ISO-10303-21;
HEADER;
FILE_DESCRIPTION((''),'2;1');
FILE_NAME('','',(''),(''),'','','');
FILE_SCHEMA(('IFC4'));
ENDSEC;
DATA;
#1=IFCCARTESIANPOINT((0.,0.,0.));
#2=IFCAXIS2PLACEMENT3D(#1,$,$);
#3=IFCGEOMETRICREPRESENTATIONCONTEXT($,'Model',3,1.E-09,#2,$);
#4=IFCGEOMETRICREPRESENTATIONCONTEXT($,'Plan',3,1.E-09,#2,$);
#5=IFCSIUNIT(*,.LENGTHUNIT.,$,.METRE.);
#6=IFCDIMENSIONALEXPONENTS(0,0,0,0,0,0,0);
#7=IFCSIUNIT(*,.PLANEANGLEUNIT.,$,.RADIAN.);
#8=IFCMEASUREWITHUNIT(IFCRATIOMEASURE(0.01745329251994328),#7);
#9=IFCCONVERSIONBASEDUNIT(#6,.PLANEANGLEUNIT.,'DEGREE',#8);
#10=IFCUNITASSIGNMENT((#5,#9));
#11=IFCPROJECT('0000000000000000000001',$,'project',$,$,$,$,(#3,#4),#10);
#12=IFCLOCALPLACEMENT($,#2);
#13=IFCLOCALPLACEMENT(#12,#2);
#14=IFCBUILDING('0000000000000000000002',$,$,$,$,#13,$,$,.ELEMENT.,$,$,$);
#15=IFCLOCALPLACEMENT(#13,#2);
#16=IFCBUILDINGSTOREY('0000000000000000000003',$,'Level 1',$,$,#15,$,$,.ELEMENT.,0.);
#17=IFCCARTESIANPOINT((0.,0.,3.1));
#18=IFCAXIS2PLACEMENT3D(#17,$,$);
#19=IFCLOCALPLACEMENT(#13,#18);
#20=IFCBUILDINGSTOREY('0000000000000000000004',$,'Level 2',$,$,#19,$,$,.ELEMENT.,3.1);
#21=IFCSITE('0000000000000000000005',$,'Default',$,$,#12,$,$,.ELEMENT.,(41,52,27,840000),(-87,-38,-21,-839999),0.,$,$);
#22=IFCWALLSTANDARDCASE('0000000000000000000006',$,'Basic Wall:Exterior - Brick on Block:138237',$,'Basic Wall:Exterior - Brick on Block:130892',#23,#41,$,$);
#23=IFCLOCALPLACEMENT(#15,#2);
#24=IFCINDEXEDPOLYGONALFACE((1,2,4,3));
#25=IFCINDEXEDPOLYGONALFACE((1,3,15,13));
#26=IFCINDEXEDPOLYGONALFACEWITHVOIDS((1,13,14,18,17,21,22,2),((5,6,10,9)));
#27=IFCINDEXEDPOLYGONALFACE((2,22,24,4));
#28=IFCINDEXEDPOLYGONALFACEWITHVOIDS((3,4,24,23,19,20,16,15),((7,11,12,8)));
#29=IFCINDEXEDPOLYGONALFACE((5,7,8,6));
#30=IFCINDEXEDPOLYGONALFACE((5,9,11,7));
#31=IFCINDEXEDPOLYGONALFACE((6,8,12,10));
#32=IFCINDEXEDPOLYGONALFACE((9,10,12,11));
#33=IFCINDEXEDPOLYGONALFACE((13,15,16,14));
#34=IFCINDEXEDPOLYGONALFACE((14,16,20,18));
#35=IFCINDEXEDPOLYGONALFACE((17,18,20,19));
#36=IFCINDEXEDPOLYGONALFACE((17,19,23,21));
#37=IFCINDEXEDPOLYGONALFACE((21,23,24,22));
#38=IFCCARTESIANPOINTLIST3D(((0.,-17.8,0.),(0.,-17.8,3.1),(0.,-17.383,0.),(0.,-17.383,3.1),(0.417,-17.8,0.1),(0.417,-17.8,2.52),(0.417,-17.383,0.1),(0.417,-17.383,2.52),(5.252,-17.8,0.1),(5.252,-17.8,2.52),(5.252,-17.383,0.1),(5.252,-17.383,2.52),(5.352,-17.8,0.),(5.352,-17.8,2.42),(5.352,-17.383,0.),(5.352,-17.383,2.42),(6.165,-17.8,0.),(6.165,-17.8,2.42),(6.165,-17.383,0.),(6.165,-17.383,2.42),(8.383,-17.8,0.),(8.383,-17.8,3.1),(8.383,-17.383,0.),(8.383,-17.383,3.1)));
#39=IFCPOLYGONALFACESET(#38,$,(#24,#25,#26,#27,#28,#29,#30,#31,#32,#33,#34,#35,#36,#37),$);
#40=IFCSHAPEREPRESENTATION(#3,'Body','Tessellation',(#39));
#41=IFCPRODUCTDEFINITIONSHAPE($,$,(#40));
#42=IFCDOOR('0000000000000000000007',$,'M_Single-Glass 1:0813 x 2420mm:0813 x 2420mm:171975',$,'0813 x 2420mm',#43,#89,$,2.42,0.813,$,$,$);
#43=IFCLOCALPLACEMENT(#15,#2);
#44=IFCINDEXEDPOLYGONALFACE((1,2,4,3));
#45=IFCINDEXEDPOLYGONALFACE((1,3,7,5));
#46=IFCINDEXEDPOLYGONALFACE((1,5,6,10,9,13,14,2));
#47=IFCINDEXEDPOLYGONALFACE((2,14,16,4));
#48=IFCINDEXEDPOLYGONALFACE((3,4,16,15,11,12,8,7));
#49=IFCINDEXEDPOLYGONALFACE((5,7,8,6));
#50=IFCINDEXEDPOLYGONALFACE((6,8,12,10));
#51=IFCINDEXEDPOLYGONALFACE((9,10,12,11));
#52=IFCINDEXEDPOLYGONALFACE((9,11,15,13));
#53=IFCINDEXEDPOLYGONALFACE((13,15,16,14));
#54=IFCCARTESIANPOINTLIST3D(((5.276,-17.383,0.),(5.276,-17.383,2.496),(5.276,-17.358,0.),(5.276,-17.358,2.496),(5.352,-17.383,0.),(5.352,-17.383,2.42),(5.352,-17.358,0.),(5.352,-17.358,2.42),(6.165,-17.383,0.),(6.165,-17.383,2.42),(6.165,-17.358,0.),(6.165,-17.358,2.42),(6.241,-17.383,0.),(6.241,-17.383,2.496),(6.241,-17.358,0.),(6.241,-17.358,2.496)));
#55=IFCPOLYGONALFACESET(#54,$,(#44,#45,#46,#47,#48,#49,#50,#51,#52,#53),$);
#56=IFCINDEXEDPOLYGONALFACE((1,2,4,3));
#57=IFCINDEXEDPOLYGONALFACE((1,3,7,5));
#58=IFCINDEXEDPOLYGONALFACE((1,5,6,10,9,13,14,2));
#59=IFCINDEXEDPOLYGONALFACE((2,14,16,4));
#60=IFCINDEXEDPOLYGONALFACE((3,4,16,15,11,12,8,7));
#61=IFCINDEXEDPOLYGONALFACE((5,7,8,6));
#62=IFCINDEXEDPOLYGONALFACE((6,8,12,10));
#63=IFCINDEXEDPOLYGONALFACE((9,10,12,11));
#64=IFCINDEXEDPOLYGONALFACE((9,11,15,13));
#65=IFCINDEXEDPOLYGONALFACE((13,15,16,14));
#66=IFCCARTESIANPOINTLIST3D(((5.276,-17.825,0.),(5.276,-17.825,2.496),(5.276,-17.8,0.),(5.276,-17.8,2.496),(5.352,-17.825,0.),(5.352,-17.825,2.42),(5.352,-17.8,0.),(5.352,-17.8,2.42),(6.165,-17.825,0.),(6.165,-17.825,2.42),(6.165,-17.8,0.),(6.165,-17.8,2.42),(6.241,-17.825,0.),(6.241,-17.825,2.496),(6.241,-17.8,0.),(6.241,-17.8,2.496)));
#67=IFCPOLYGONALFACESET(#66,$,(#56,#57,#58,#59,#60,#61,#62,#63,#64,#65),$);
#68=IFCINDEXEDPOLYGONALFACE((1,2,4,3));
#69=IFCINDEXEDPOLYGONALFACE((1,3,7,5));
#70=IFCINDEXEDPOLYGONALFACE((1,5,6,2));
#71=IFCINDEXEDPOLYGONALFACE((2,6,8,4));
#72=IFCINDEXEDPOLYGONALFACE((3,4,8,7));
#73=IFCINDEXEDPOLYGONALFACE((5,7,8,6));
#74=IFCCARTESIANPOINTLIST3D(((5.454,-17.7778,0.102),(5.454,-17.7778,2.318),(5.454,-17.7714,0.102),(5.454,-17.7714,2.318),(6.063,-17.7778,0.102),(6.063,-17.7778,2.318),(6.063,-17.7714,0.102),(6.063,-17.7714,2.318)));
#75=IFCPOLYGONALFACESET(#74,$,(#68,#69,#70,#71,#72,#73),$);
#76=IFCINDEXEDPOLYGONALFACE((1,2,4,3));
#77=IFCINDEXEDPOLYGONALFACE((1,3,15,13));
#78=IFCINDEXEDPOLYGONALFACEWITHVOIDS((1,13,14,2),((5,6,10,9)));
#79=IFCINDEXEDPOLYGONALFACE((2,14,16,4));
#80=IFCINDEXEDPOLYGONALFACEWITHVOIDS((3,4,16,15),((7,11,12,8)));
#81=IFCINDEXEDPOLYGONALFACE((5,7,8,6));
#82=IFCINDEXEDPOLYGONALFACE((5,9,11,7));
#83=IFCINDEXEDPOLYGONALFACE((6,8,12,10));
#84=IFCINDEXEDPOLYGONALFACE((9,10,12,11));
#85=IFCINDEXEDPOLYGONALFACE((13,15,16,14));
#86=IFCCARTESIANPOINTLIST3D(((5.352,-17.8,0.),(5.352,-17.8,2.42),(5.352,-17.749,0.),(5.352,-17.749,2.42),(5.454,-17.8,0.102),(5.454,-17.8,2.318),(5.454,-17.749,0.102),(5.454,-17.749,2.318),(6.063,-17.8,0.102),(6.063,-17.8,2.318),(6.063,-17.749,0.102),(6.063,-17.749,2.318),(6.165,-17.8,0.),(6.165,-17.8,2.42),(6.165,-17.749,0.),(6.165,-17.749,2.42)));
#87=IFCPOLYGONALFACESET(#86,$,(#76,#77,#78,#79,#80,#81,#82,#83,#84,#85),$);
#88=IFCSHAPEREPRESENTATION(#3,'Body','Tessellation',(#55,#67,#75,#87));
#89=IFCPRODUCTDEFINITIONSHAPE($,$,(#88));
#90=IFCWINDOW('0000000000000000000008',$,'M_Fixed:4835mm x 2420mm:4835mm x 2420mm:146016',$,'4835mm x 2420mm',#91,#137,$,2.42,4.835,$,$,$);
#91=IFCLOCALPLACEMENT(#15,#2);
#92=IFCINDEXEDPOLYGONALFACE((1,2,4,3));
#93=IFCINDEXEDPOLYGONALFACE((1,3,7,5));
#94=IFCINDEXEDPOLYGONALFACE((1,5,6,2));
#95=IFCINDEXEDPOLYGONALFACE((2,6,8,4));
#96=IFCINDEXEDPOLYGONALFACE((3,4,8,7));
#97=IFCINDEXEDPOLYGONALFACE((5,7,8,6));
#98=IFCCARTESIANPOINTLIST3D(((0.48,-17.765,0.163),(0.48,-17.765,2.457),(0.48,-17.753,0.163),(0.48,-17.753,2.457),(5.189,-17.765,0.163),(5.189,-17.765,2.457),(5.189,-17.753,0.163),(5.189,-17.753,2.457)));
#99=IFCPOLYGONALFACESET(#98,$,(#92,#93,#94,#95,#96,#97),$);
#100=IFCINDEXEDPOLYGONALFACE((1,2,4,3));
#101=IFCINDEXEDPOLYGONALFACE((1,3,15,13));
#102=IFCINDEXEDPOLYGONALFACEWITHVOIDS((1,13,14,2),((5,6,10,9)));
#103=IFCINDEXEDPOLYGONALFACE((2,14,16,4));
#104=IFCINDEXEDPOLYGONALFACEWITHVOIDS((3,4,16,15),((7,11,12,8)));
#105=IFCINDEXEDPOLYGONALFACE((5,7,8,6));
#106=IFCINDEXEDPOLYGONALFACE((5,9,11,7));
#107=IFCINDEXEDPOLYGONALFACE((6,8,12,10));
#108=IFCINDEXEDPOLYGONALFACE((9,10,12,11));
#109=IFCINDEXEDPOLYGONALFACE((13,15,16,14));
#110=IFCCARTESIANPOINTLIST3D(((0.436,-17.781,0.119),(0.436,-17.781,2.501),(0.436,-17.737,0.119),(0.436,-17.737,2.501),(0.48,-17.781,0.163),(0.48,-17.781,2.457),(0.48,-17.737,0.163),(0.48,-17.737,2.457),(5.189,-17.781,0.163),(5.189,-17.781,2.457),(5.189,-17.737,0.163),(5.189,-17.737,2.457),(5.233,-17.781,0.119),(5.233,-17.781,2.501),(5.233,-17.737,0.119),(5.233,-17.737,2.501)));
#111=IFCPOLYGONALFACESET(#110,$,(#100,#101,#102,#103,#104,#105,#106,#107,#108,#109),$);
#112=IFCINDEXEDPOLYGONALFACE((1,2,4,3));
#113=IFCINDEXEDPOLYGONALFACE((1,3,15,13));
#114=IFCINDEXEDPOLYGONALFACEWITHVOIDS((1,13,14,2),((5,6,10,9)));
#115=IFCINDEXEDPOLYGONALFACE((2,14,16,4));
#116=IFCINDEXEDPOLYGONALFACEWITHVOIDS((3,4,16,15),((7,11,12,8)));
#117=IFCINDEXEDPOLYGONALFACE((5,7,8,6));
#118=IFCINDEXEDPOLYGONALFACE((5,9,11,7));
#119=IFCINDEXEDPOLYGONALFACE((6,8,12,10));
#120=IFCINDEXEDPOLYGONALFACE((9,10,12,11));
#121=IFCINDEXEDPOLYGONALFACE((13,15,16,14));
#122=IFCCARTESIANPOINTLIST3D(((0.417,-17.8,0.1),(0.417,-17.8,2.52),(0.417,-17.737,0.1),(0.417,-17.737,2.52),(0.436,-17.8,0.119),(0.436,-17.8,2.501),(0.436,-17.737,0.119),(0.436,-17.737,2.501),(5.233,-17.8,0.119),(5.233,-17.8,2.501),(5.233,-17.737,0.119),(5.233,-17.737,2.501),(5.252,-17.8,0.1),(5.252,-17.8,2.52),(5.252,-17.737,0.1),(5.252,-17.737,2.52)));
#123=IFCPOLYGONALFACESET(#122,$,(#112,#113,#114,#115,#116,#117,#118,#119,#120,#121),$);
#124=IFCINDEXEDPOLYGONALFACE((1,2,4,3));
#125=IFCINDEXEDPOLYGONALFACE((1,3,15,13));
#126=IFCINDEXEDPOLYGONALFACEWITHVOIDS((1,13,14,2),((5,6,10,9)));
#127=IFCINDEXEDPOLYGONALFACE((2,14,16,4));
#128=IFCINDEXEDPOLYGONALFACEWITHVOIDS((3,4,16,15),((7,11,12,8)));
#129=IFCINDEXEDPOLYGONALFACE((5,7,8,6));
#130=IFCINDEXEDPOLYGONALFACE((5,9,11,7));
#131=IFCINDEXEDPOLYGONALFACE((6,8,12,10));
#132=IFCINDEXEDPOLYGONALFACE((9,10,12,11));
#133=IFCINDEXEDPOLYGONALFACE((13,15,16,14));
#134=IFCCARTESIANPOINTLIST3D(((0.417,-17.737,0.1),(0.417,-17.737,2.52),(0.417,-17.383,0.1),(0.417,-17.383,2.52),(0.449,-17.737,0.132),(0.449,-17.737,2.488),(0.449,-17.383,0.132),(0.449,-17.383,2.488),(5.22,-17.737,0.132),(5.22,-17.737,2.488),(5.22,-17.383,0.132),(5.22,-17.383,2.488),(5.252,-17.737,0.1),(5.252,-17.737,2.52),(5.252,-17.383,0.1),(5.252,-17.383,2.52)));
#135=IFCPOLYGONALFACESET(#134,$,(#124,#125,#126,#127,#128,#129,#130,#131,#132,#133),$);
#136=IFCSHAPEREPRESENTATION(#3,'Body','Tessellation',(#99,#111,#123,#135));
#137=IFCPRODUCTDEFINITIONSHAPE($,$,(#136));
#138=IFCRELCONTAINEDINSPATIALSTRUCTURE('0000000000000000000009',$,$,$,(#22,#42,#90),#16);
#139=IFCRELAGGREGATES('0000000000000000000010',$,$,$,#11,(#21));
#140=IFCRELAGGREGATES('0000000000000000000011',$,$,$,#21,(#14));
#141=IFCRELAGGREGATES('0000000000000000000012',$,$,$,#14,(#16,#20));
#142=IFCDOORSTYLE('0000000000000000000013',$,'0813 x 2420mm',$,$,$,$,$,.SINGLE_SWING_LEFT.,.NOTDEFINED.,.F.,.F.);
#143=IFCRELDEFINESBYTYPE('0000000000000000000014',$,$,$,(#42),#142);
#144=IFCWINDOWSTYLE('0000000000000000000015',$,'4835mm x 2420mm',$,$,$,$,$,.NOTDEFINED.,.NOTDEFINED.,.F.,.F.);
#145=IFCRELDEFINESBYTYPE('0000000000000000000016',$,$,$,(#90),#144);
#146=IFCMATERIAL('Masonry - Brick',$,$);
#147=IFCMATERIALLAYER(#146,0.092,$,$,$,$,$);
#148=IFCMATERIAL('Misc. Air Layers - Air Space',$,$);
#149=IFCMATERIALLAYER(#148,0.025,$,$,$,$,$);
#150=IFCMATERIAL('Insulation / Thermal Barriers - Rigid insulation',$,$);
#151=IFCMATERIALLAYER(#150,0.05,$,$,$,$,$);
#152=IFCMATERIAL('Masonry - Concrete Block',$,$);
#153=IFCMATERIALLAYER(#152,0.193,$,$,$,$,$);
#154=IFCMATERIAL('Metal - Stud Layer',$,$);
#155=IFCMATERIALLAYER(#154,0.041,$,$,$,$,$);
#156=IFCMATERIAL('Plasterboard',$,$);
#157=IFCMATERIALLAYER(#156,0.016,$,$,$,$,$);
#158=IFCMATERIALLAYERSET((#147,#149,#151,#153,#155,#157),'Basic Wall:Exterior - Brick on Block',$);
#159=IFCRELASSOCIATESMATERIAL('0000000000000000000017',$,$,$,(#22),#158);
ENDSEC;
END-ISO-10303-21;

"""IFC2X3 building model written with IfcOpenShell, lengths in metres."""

from ifc_helpers import new_model, entity, si_unit, converted_unit, frame, frame_2d, origin, origin_2d_with_axis, place, context, project, spatial, polyline, rectangle, outline, extrude, source, transform, mapped, material, layer, layer_set, layer_usage, type_object, type_shapes, element, fill, save


model = new_model("IFC2X3")

# Units and contexts
model_context = context("Model", 3, precision=1e-09, world=origin())
plan_context = context("Plan", 3, precision=1e-09, world=origin())
ifc_project = project(units=[si_unit("LENGTHUNIT", "METRE"), converted_unit("PLANEANGLEUNIT", "DEGREE", entity("IfcRatioMeasure", 0.01745329251994328), si_unit("PLANEANGLEUNIT", "RADIAN"), dimensions=[0, 0, 0, 0, 0, 0, 0])], contexts=[model_context, plan_context])

# Site, building, storey
site_placement = place(None, origin())
site = spatial("IfcSite", under=ifc_project, at=site_placement, Name="Default", CompositionType="ELEMENT", RefLatitude=(41, 52, 27, 840000), RefLongitude=(-87, -38, -21, -839999), RefElevation=0.0)
building_placement = place(site_placement, origin())
building = spatial("IfcBuilding", under=site, at=building_placement, CompositionType="ELEMENT")
storey_1_placement = place(building_placement, origin())
storey_1 = spatial("IfcBuildingStorey", under=building, at=storey_1_placement, Name="Level 1", CompositionType="ELEMENT", Elevation=0.0)

# Shared definitions
ifc_material_1 = material(Name="Masonry - Brick")
ifc_layer_1 = layer(ifc_material_1, 0.092)
ifc_material_2 = material(Name="Misc. Air Layers - Air Space")
ifc_layer_2 = layer(ifc_material_2, 0.025)
ifc_material_3 = material(Name="Insulation / Thermal Barriers - Rigid insulation")
ifc_layer_3 = layer(ifc_material_3, 0.05)
ifc_material_4 = material(Name="Masonry - Concrete Block")
ifc_layer_4 = layer(ifc_material_4, 0.193)
ifc_material_5 = material(Name="Metal - Stud Layer")
ifc_layer_5 = layer(ifc_material_5, 0.041)
ifc_material_6 = material(Name="Plasterboard")
ifc_layer_6 = layer(ifc_material_6, 0.016)
ifc_layer_set_1 = layer_set([ifc_layer_1, ifc_layer_2, ifc_layer_3, ifc_layer_4, ifc_layer_5, ifc_layer_6], Name="Basic Wall:Exterior - Brick on Block")
ifc_layer_usage_1 = layer_usage(ifc_layer_set_1, "AXIS2", "NEGATIVE", 0.2085)

# Shared definitions
storey_2_placement = place(building_placement, frame((0.0, 0.0, 3.1)))
storey_2 = spatial("IfcBuildingStorey", under=building, at=storey_2_placement, Name="Level 2", CompositionType="ELEMENT", Elevation=3.1)

# Wall, openings, door, window
wall_1_placement = place(storey_1_placement, frame((8.383, -17.5915, 0.0), z_axis=(0.0, 0.0, 1.0), x_axis=(-1.0, 0.0, 0.0)))
wall_1 = element("IfcWallStandardCase", 1, at=wall_1_placement, inside=storey_1, material=ifc_layer_usage_1, Name="Basic Wall:Exterior - Brick on Block:138237", ObjectType="Basic Wall:Exterior - Brick on Block:130892", context=model_context, shape_type="SweptSolid", body=[
    extrude(rectangle(XDim=8.383, YDim=0.417, at=frame_2d((4.1915, 0.0), x_axis=(-1.0, 0.0))), origin(), (0.0, 0.0, 1.0), 3.1),
])
opening_1_placement = place(wall_1_placement, frame((3.131, -0.2085, 0.1)))
opening_1 = element("IfcOpeningElement", 2, at=opening_1_placement, cuts=wall_1, ObjectType="Opening", context=model_context, shape_type="SweptSolid", body=[
    extrude(rectangle(XDim=2.42, YDim=4.835, at=frame_2d((1.21, 2.4175), x_axis=(1.0, 0.0))), frame((0.0, 0.0, 0.0), z_axis=(0.0, 1.0, 0.0), x_axis=(0.0, 0.0, 1.0)), (0.0, 0.0, 1.0), 0.417),
])
opening_2_placement = place(wall_1_placement, frame((2.218, -0.2085, 0.0)))
opening_2 = element("IfcOpeningElement", 3, at=opening_2_placement, cuts=wall_1, ObjectType="Opening", context=model_context, shape_type="SweptSolid", body=[
    extrude(rectangle(XDim=0.813, YDim=2.42, at=frame_2d((1.21, 0.4065), x_axis=(0.0, -1.0))), frame((0.0, 0.0, 0.0), z_axis=(0.0, 1.0, 0.0), x_axis=(0.0, 0.0, 1.0)), (0.0, 0.0, 1.0), 0.417),
])
door_style_1 = type_object("IfcDoorStyle", Name="0813 x 2420mm", ConstructionType="NOTDEFINED", OperationType="SINGLE_SWING_LEFT", ParameterTakesPrecedence=False, Sizeable=False)
shared_shape_1 = source(origin(), model_context, "Body", "SweptSolid", [
    extrude(outline(polyline([(-0.4065, -1.191), (-0.4065, 1.229), (-0.4825, 1.229), (-0.4825, -1.267), (0.4825, -1.267), (0.4825, 1.229), (0.4065, 1.229), (0.4065, -1.191), (-0.4065, -1.191)])), frame((0.4065, 0.0, 1.229), z_axis=(0.0, 1.0, 0.0), x_axis=(1.0, 0.0, 0.0)), (0.0, 0.0, -1.0), 0.025),
    extrude(outline(polyline([(-0.4065, -1.191), (-0.4065, 1.229), (-0.4825, 1.229), (-0.4825, -1.267), (0.4825, -1.267), (0.4825, 1.229), (0.4065, 1.229), (0.4065, -1.191), (-0.4065, -1.191)])), frame((0.4065, 0.442, 1.229), z_axis=(0.0, 1.0, 0.0), x_axis=(1.0, 0.0, 0.0)), (0.0, 0.0, -1.0), 0.025),
    extrude(rectangle(XDim=0.609, YDim=0.0064, at=origin_2d_with_axis()), frame((0.4065, 0.3916, 0.102)), (0.0, 0.0, 1.0), 2.216),
    extrude(outline(polyline([(-1.21, -0.4065), (1.21, -0.4065), (1.21, 0.4065), (-1.21, 0.4065), (-1.21, -0.4065)]), holes=[polyline([(-1.108, 0.3045), (1.108, 0.3045), (1.108, -0.3045), (-1.108, -0.3045), (-1.108, 0.3045)])]), frame((0.4065, 0.417, 1.21), z_axis=(0.0, -1.0, 0.0), x_axis=(0.0, 0.0, -1.0)), (0.0, 0.0, 1.0), 0.051),
])
type_shapes(door_style_1, [shared_shape_1])
door_1_placement = place(opening_2_placement, origin())
door_1 = element("IfcDoor", 4, at=door_1_placement, inside=storey_1, type_object=door_style_1, Name="M_Single-Glass 1:0813 x 2420mm:0813 x 2420mm:171975", ObjectType="0813 x 2420mm", OverallHeight=2.42, OverallWidth=0.813, context=model_context, shape_type="MappedRepresentation", body=[
    mapped(shared_shape_1, transform((0.0, 0.0, 0.0), scale=1.0)),
])
fill(opening_2, door_1)
window_style_1 = type_object("IfcWindowStyle", Name="4835mm x 2420mm", ConstructionType="NOTDEFINED", OperationType="NOTDEFINED", ParameterTakesPrecedence=False, Sizeable=False)
shared_shape_2 = source(origin(), model_context, "Body", "SweptSolid", [
    extrude(rectangle(XDim=0.012, YDim=4.709, at=origin_2d_with_axis()), frame((2.4175, 0.376, 0.063), z_axis=(0.0, 0.0, 1.0), x_axis=(0.0, -1.0, 0.0)), (0.0, 0.0, 1.0), 2.294),
    extrude(outline(polyline([(-2.3985, -1.191), (2.3985, -1.191), (2.3985, 1.191), (-2.3985, 1.191), (-2.3985, -1.191)]), holes=[polyline([(-2.3545, -1.147), (-2.3545, 1.147), (2.3545, 1.147), (2.3545, -1.147), (-2.3545, -1.147)])]), frame((2.4175, 0.354, 1.21), z_axis=(0.0, 1.0, 0.0), x_axis=(1.0, 0.0, 0.0)), (0.0, 0.0, 1.0), 0.044),
    extrude(outline(polyline([(-2.4175, -1.21), (2.4175, -1.21), (2.4175, 1.21), (-2.4175, 1.21), (-2.4175, -1.21)]), holes=[polyline([(-2.3985, -1.191), (-2.3985, 1.191), (2.3985, 1.191), (2.3985, -1.191), (-2.3985, -1.191)])]), frame((2.4175, 0.354, 1.21), z_axis=(0.0, 1.0, 0.0), x_axis=(1.0, 0.0, 0.0)), (0.0, 0.0, 1.0), 0.063),
    extrude(outline(polyline([(-2.4175, -1.21), (2.4175, -1.21), (2.4175, 1.21), (-2.4175, 1.21), (-2.4175, -1.21)]), holes=[polyline([(-2.3855, -1.178), (-2.3855, 1.178), (2.3855, 1.178), (2.3855, -1.178), (-2.3855, -1.178)])]), frame((2.4175, 0.0, 1.21), z_axis=(0.0, 1.0, 0.0), x_axis=(1.0, 0.0, 0.0)), (0.0, 0.0, 1.0), 0.354),
])
type_shapes(window_style_1, [shared_shape_2])
window_1_placement = place(opening_1_placement, origin())
window_1 = element("IfcWindow", 5, at=window_1_placement, inside=storey_1, type_object=window_style_1, Name="M_Fixed:4835mm x 2420mm:4835mm x 2420mm:146016", ObjectType="4835mm x 2420mm", OverallHeight=2.42, OverallWidth=4.835, context=model_context, shape_type="MappedRepresentation", body=[
    mapped(shared_shape_2, transform((0.0, 0.0, 0.0), scale=1.0)),
])
fill(opening_1, window_1)

save(model, "model.ifc")
